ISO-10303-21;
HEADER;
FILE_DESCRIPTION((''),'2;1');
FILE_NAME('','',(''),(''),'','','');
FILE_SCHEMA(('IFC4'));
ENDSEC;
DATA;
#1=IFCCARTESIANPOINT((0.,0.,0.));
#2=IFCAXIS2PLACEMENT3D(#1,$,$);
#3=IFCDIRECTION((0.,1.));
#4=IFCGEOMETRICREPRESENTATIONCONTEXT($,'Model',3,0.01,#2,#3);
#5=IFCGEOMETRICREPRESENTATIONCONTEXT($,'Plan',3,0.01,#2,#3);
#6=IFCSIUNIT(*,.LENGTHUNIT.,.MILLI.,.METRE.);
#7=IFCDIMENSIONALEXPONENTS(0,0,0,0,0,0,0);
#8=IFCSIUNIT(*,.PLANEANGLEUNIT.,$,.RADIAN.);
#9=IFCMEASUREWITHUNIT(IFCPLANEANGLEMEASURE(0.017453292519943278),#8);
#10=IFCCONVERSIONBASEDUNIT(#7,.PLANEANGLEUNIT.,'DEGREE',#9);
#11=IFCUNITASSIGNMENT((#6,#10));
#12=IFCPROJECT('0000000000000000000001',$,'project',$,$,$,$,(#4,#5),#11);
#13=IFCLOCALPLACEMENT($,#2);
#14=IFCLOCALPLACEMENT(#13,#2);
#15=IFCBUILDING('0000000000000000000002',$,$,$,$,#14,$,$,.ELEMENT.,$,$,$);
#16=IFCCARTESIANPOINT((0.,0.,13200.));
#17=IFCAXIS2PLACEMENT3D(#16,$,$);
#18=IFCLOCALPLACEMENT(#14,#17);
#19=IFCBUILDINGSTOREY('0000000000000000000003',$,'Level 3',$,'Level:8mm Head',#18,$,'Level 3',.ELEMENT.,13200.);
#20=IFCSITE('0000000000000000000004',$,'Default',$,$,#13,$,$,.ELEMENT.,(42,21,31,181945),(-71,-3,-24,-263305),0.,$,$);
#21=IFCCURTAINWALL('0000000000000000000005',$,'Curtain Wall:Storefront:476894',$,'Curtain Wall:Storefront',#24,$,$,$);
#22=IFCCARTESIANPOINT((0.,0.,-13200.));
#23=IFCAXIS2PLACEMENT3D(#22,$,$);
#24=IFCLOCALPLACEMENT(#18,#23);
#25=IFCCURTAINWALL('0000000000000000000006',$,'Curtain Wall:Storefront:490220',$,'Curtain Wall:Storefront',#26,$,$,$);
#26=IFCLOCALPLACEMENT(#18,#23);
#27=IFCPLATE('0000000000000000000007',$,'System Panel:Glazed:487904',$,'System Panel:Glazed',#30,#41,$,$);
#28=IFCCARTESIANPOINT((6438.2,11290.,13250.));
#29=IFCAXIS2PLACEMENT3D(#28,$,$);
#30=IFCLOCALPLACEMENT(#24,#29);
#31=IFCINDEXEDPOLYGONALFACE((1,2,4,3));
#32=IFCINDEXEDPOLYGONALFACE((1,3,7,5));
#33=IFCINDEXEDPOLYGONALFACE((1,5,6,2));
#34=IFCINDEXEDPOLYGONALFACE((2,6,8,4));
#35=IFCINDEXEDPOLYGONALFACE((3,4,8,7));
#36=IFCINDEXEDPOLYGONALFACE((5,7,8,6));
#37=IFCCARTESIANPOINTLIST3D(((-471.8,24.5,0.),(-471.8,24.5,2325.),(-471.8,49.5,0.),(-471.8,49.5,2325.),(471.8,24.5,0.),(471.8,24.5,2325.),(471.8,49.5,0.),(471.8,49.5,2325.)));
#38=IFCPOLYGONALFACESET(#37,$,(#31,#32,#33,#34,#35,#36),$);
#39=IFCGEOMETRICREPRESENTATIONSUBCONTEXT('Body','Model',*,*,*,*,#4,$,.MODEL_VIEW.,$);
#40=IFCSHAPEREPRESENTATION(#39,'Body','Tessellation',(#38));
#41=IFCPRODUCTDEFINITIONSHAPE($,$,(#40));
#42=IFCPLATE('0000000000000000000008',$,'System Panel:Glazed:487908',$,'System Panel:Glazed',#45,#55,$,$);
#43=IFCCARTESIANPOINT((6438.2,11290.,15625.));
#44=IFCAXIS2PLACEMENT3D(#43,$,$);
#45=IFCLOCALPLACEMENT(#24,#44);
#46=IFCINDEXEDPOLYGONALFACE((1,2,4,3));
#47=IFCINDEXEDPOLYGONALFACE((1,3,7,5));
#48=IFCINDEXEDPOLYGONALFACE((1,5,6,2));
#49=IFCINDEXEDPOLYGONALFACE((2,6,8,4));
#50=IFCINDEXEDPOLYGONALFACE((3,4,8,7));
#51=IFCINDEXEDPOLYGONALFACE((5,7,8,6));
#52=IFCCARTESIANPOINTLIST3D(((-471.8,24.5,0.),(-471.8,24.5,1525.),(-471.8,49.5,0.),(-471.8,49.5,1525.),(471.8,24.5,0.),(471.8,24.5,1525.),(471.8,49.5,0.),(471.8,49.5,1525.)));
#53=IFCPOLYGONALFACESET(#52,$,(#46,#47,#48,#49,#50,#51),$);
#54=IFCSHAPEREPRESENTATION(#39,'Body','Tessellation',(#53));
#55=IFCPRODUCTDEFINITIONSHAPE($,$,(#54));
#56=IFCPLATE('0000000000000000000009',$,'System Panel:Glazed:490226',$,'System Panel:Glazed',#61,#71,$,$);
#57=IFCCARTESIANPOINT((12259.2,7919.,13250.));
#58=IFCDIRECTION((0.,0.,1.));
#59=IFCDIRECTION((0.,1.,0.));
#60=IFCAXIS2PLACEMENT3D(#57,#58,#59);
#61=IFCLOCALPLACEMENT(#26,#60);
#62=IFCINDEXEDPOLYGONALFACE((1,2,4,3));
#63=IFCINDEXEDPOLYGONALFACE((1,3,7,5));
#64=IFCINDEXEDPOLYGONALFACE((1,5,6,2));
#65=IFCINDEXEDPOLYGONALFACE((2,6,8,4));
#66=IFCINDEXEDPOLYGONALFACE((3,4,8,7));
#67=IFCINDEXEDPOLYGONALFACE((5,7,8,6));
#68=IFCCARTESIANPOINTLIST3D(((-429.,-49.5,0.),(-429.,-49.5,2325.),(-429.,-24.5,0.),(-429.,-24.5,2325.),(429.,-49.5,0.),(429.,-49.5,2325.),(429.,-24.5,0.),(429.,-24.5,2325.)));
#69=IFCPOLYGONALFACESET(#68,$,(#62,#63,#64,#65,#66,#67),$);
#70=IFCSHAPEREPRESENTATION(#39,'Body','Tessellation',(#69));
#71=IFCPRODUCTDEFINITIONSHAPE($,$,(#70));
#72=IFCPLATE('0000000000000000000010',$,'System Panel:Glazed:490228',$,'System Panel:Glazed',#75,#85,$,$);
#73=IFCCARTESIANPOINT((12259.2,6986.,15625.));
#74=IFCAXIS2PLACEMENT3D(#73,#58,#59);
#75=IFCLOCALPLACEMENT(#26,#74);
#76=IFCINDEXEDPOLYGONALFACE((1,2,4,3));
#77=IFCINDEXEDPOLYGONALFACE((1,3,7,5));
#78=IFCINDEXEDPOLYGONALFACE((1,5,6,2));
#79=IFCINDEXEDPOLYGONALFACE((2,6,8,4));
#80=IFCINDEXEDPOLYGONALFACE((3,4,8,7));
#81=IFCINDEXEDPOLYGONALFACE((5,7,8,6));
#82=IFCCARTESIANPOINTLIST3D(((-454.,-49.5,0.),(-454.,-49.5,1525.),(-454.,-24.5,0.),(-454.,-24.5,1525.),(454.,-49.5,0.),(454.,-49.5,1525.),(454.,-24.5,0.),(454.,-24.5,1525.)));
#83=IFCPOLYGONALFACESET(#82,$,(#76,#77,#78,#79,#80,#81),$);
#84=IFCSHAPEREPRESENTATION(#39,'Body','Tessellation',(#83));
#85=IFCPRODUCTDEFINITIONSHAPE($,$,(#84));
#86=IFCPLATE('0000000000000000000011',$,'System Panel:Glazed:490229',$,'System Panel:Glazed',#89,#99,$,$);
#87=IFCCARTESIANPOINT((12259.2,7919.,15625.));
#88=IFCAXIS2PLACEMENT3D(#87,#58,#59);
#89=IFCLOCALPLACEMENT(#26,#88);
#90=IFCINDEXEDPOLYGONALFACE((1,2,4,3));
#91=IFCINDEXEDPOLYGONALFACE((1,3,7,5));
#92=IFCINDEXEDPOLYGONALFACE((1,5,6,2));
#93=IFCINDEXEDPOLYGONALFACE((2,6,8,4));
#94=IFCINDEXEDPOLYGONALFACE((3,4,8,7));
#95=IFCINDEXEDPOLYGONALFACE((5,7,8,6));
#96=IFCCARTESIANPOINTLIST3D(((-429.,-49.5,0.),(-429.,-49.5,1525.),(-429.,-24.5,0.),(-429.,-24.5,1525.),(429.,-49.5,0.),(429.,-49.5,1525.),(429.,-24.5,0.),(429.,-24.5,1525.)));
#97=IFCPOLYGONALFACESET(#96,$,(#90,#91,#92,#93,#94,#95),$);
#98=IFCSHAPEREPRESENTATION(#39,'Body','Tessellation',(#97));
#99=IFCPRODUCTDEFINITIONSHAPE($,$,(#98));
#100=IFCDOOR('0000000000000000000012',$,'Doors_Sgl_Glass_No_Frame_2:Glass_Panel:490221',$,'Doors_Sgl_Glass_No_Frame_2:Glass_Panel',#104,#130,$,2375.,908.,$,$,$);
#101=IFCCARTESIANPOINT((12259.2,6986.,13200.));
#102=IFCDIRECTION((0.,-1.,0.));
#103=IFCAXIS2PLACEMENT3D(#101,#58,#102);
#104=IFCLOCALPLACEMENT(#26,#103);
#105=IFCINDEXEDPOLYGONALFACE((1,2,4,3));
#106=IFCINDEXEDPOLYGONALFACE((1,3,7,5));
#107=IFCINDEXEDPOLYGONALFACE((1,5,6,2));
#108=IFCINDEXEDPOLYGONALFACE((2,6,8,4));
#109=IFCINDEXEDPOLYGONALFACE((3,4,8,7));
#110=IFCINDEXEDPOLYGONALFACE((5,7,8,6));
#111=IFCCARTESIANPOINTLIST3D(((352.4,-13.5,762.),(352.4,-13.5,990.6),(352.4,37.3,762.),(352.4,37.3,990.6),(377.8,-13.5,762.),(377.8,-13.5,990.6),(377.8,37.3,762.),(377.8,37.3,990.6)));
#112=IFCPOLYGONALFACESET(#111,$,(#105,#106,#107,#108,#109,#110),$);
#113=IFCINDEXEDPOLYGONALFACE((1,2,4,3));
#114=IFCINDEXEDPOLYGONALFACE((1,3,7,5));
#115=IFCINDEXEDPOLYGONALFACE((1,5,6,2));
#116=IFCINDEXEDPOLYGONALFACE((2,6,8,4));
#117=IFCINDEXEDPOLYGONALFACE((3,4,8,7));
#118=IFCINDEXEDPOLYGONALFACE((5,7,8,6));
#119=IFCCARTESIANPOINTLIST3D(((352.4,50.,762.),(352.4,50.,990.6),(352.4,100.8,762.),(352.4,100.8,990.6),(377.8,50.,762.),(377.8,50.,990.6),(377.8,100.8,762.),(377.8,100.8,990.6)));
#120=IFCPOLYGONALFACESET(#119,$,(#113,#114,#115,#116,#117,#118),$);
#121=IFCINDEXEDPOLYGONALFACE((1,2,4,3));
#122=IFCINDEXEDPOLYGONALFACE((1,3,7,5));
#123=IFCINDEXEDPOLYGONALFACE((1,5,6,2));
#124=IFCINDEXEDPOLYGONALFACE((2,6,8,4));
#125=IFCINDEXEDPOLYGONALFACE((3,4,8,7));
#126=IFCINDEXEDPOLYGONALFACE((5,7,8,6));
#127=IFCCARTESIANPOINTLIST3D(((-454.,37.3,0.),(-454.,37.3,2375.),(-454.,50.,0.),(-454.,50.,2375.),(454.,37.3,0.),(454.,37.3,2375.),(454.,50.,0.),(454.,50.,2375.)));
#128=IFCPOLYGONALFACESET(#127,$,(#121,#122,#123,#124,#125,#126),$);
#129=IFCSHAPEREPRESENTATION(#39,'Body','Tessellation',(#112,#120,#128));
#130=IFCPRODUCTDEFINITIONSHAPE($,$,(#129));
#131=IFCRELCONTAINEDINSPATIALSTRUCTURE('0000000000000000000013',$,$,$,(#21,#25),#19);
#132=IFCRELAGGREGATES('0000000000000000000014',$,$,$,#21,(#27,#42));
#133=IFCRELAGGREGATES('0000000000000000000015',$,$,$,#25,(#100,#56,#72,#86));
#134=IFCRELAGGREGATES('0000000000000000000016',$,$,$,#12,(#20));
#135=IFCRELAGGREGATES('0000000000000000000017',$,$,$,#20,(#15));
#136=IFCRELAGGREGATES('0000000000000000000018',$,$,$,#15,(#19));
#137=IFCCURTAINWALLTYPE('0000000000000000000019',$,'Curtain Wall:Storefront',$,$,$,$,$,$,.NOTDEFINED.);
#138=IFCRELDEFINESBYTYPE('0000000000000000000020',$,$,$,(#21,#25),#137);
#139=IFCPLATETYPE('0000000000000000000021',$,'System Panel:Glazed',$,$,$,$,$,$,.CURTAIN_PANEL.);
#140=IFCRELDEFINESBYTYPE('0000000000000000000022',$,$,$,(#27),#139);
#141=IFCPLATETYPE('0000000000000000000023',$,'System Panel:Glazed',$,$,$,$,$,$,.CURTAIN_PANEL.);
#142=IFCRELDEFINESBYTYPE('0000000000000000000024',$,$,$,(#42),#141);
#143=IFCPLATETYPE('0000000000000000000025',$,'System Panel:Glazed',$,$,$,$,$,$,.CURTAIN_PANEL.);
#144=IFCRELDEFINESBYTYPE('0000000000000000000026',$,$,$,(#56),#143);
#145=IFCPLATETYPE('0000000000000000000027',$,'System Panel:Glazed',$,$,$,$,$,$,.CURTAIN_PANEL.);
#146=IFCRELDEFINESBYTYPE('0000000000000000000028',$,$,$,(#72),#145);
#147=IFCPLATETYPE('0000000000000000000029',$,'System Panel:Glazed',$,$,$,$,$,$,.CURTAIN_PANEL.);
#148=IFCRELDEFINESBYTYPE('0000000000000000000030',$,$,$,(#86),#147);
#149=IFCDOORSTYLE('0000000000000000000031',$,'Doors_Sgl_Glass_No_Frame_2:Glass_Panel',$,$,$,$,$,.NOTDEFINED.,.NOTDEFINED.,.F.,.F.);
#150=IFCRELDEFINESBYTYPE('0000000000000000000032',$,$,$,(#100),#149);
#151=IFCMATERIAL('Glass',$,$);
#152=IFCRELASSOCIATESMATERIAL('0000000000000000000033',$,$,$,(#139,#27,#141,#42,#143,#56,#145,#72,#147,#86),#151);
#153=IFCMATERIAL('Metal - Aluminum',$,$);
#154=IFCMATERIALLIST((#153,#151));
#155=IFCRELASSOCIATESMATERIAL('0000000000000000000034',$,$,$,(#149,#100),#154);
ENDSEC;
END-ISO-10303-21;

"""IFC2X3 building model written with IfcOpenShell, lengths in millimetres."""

from ifc_helpers import new_model, entity, si_unit, converted_unit, direction, frame, frame_2d, origin, origin_2d_with_axis, place, context, subcontext, project, spatial, rectangle, extrude, source, transform, mapped, material, material_list, type_object, type_shapes, element, aggregate, save


model = new_model("IFC2X3")

# Units and contexts
model_context = context("Model", 3, precision=0.01, world=origin(), true_north=direction((0.0, 1.0)))
plan_context = context("Plan", 3, precision=0.01, world=origin(), true_north=direction((0.0, 1.0)))
body_context = subcontext(model_context, "Body", "Model", "MODEL_VIEW")
ifc_project = project(units=[si_unit("LENGTHUNIT", "METRE", prefix="MILLI"), converted_unit("PLANEANGLEUNIT", "DEGREE", entity("IfcPlaneAngleMeasure", 0.017453292519943278), si_unit("PLANEANGLEUNIT", "RADIAN"), dimensions=[0, 0, 0, 0, 0, 0, 0])], contexts=[model_context, plan_context])

# Site, building, storey
site_placement = place(None, origin())
site = spatial("IfcSite", under=ifc_project, at=site_placement, Name="Default", CompositionType="ELEMENT", RefLatitude=(42, 21, 31, 181945), RefLongitude=(-71, -3, -24, -263305), RefElevation=0.0)
building_placement = place(site_placement, origin())
building = spatial("IfcBuilding", under=site, at=building_placement, CompositionType="ELEMENT")
storey_placement = place(building_placement, frame((0.0, 0.0, 13200.0)))
storey = spatial("IfcBuildingStorey", under=building, at=storey_placement, Name="Level 3", ObjectType="Level:8mm Head", LongName="Level 3", CompositionType="ELEMENT", Elevation=13200.0)

# Curtain wall
curtain_wall_type = type_object("IfcCurtainWallType", Name="Curtain Wall:Storefront", PredefinedType="NOTDEFINED")
curtain_wall_1_placement = place(storey_placement, frame((0.0, 0.0, -13200.0)))
curtain_wall_1 = element("IfcCurtainWall", 1, at=curtain_wall_1_placement, inside=storey, type_object=curtain_wall_type, Name="Curtain Wall:Storefront:476894", ObjectType="Curtain Wall:Storefront")

# Curtain wall
curtain_wall_2_placement = place(storey_placement, frame((0.0, 0.0, -13200.0)))
curtain_wall_2 = element("IfcCurtainWall", 2, at=curtain_wall_2_placement, inside=storey, type_object=curtain_wall_type, Name="Curtain Wall:Storefront:490220", ObjectType="Curtain Wall:Storefront")

# Plates
ifc_material_1 = material(Name="Glass")
plate_type_1 = type_object("IfcPlateType", Name="System Panel:Glazed", PredefinedType="CURTAIN_PANEL", material=ifc_material_1)
shared_shape_1 = source(origin(), body_context, "Body", "SweptSolid", [
    extrude(rectangle(XDim=25.0, YDim=943.5, at=origin_2d_with_axis()), frame((0.0, 37.0, 0.0), z_axis=(0.0, 0.0, 1.0), x_axis=(0.0, 1.0, 0.0)), (0.0, 0.0, 1.0), 2325.0),
])
type_shapes(plate_type_1, [shared_shape_1])
plate_1_placement = place(curtain_wall_1_placement, frame((6438.2, 11290.0, 13250.0)))
plate_1 = element("IfcPlate", 3, at=plate_1_placement, type_object=plate_type_1, material=ifc_material_1, Name="System Panel:Glazed:487904", ObjectType="System Panel:Glazed", context=body_context, shape_type="MappedRepresentation", body=[
    mapped(shared_shape_1, transform((0.0, 0.0, 0.0), scale=1.0)),
])
plate_type_2 = type_object("IfcPlateType", Name="System Panel:Glazed", PredefinedType="CURTAIN_PANEL", material=ifc_material_1)
shared_shape_2 = source(origin(), body_context, "Body", "SweptSolid", [
    extrude(rectangle(XDim=25.0, YDim=943.5, at=origin_2d_with_axis()), frame((0.0, 37.0, 0.0), z_axis=(0.0, 0.0, 1.0), x_axis=(0.0, 1.0, 0.0)), (0.0, 0.0, 1.0), 1525.0),
])
type_shapes(plate_type_2, [shared_shape_2])
plate_2_placement = place(curtain_wall_1_placement, frame((6438.2, 11290.0, 15625.0)))
plate_2 = element("IfcPlate", 4, at=plate_2_placement, type_object=plate_type_2, material=ifc_material_1, Name="System Panel:Glazed:487908", ObjectType="System Panel:Glazed", context=body_context, shape_type="MappedRepresentation", body=[
    mapped(shared_shape_2, transform((0.0, 0.0, 0.0), scale=1.0)),
])
aggregate(curtain_wall_1, [plate_1, plate_2])
plate_type_3 = type_object("IfcPlateType", Name="System Panel:Glazed", PredefinedType="CURTAIN_PANEL", material=ifc_material_1)
shared_shape_3 = source(origin(), body_context, "Body", "SweptSolid", [
    extrude(rectangle(XDim=25.0, YDim=858.0, at=origin_2d_with_axis()), frame((0.0, -37.0, 0.0), z_axis=(0.0, 0.0, 1.0), x_axis=(0.0, 1.0, 0.0)), (0.0, 0.0, 1.0), 2325.0),
])
type_shapes(plate_type_3, [shared_shape_3])
plate_3_placement = place(curtain_wall_2_placement, frame((12259.2, 7919.0, 13250.0), z_axis=(0.0, 0.0, 1.0), x_axis=(0.0, 1.0, 0.0)))
plate_3 = element("IfcPlate", 5, at=plate_3_placement, type_object=plate_type_3, material=ifc_material_1, Name="System Panel:Glazed:490226", ObjectType="System Panel:Glazed", context=body_context, shape_type="MappedRepresentation", body=[
    mapped(shared_shape_3, transform((0.0, 0.0, 0.0), scale=1.0)),
])
plate_type_4 = type_object("IfcPlateType", Name="System Panel:Glazed", PredefinedType="CURTAIN_PANEL", material=ifc_material_1)
shared_shape_4 = source(origin(), body_context, "Body", "SweptSolid", [
    extrude(rectangle(XDim=25.0, YDim=908.0, at=origin_2d_with_axis()), frame((0.0, -37.0, 0.0), z_axis=(0.0, 0.0, 1.0), x_axis=(0.0, 1.0, 0.0)), (0.0, 0.0, 1.0), 1525.0),
])
type_shapes(plate_type_4, [shared_shape_4])
plate_4_placement = place(curtain_wall_2_placement, frame((12259.2, 6986.0, 15625.0), z_axis=(0.0, 0.0, 1.0), x_axis=(0.0, 1.0, 0.0)))
plate_4 = element("IfcPlate", 6, at=plate_4_placement, type_object=plate_type_4, material=ifc_material_1, Name="System Panel:Glazed:490228", ObjectType="System Panel:Glazed", context=body_context, shape_type="MappedRepresentation", body=[
    mapped(shared_shape_4, transform((0.0, 0.0, 0.0), scale=1.0)),
])
plate_type_5 = type_object("IfcPlateType", Name="System Panel:Glazed", PredefinedType="CURTAIN_PANEL", material=ifc_material_1)
shared_shape_5 = source(origin(), body_context, "Body", "SweptSolid", [
    extrude(rectangle(XDim=25.0, YDim=858.0, at=origin_2d_with_axis()), frame((0.0, -37.0, 0.0), z_axis=(0.0, 0.0, 1.0), x_axis=(0.0, 1.0, 0.0)), (0.0, 0.0, 1.0), 1525.0),
])
type_shapes(plate_type_5, [shared_shape_5])
plate_5_placement = place(curtain_wall_2_placement, frame((12259.2, 7919.0, 15625.0), z_axis=(0.0, 0.0, 1.0), x_axis=(0.0, 1.0, 0.0)))
plate_5 = element("IfcPlate", 7, at=plate_5_placement, type_object=plate_type_5, material=ifc_material_1, Name="System Panel:Glazed:490229", ObjectType="System Panel:Glazed", context=body_context, shape_type="MappedRepresentation", body=[
    mapped(shared_shape_5, transform((0.0, 0.0, 0.0), scale=1.0)),
])

# Door
ifc_material_2 = material(Name="Metal - Aluminum")
ifc_material_list = material_list([ifc_material_2, ifc_material_1])
door_style = type_object("IfcDoorStyle", Name="Doors_Sgl_Glass_No_Frame_2:Glass_Panel", ConstructionType="NOTDEFINED", OperationType="NOTDEFINED", ParameterTakesPrecedence=False, Sizeable=False, material=ifc_material_list)
shared_shape_6 = source(origin(), body_context, "Body", "SweptSolid", [
    extrude(rectangle(XDim=25.4, YDim=50.8, at=origin_2d_with_axis()), frame((365.1, 11.9, 762.0)), (0.0, 0.0, 1.0), 228.6),
    extrude(rectangle(XDim=25.4, YDim=50.8, at=frame_2d((0.0, 0.0), x_axis=(1.0, 0.0))), frame((365.1, 75.4, 762.0), z_axis=(0.0, 0.0, 1.0), x_axis=(-1.0, 0.0, 0.0)), (0.0, 0.0, 1.0), 228.6),
    extrude(rectangle(XDim=12.7, YDim=908.0, at=frame_2d((0.0, 0.0), x_axis=(1.0, 0.0))), frame((0.0, 43.7, 0.0), z_axis=(0.0, 0.0, 1.0), x_axis=(0.0, -1.0, 0.0)), (0.0, 0.0, 1.0), 2375.0),
])
type_shapes(door_style, [shared_shape_6])
door_placement = place(curtain_wall_2_placement, frame((12259.2, 6986.0, 13200.0), z_axis=(0.0, 0.0, 1.0), x_axis=(0.0, -1.0, 0.0)))
door = element("IfcDoor", 8, at=door_placement, type_object=door_style, material=ifc_material_list, Name="Doors_Sgl_Glass_No_Frame_2:Glass_Panel:490221", ObjectType="Doors_Sgl_Glass_No_Frame_2:Glass_Panel", OverallHeight=2375.0, OverallWidth=908.0, context=body_context, shape_type="MappedRepresentation", body=[
    mapped(shared_shape_6, transform((0.0, 0.0, 0.0), scale=1.0)),
])
aggregate(curtain_wall_2, [door, plate_3, plate_4, plate_5])

save(model, "model.ifc")
